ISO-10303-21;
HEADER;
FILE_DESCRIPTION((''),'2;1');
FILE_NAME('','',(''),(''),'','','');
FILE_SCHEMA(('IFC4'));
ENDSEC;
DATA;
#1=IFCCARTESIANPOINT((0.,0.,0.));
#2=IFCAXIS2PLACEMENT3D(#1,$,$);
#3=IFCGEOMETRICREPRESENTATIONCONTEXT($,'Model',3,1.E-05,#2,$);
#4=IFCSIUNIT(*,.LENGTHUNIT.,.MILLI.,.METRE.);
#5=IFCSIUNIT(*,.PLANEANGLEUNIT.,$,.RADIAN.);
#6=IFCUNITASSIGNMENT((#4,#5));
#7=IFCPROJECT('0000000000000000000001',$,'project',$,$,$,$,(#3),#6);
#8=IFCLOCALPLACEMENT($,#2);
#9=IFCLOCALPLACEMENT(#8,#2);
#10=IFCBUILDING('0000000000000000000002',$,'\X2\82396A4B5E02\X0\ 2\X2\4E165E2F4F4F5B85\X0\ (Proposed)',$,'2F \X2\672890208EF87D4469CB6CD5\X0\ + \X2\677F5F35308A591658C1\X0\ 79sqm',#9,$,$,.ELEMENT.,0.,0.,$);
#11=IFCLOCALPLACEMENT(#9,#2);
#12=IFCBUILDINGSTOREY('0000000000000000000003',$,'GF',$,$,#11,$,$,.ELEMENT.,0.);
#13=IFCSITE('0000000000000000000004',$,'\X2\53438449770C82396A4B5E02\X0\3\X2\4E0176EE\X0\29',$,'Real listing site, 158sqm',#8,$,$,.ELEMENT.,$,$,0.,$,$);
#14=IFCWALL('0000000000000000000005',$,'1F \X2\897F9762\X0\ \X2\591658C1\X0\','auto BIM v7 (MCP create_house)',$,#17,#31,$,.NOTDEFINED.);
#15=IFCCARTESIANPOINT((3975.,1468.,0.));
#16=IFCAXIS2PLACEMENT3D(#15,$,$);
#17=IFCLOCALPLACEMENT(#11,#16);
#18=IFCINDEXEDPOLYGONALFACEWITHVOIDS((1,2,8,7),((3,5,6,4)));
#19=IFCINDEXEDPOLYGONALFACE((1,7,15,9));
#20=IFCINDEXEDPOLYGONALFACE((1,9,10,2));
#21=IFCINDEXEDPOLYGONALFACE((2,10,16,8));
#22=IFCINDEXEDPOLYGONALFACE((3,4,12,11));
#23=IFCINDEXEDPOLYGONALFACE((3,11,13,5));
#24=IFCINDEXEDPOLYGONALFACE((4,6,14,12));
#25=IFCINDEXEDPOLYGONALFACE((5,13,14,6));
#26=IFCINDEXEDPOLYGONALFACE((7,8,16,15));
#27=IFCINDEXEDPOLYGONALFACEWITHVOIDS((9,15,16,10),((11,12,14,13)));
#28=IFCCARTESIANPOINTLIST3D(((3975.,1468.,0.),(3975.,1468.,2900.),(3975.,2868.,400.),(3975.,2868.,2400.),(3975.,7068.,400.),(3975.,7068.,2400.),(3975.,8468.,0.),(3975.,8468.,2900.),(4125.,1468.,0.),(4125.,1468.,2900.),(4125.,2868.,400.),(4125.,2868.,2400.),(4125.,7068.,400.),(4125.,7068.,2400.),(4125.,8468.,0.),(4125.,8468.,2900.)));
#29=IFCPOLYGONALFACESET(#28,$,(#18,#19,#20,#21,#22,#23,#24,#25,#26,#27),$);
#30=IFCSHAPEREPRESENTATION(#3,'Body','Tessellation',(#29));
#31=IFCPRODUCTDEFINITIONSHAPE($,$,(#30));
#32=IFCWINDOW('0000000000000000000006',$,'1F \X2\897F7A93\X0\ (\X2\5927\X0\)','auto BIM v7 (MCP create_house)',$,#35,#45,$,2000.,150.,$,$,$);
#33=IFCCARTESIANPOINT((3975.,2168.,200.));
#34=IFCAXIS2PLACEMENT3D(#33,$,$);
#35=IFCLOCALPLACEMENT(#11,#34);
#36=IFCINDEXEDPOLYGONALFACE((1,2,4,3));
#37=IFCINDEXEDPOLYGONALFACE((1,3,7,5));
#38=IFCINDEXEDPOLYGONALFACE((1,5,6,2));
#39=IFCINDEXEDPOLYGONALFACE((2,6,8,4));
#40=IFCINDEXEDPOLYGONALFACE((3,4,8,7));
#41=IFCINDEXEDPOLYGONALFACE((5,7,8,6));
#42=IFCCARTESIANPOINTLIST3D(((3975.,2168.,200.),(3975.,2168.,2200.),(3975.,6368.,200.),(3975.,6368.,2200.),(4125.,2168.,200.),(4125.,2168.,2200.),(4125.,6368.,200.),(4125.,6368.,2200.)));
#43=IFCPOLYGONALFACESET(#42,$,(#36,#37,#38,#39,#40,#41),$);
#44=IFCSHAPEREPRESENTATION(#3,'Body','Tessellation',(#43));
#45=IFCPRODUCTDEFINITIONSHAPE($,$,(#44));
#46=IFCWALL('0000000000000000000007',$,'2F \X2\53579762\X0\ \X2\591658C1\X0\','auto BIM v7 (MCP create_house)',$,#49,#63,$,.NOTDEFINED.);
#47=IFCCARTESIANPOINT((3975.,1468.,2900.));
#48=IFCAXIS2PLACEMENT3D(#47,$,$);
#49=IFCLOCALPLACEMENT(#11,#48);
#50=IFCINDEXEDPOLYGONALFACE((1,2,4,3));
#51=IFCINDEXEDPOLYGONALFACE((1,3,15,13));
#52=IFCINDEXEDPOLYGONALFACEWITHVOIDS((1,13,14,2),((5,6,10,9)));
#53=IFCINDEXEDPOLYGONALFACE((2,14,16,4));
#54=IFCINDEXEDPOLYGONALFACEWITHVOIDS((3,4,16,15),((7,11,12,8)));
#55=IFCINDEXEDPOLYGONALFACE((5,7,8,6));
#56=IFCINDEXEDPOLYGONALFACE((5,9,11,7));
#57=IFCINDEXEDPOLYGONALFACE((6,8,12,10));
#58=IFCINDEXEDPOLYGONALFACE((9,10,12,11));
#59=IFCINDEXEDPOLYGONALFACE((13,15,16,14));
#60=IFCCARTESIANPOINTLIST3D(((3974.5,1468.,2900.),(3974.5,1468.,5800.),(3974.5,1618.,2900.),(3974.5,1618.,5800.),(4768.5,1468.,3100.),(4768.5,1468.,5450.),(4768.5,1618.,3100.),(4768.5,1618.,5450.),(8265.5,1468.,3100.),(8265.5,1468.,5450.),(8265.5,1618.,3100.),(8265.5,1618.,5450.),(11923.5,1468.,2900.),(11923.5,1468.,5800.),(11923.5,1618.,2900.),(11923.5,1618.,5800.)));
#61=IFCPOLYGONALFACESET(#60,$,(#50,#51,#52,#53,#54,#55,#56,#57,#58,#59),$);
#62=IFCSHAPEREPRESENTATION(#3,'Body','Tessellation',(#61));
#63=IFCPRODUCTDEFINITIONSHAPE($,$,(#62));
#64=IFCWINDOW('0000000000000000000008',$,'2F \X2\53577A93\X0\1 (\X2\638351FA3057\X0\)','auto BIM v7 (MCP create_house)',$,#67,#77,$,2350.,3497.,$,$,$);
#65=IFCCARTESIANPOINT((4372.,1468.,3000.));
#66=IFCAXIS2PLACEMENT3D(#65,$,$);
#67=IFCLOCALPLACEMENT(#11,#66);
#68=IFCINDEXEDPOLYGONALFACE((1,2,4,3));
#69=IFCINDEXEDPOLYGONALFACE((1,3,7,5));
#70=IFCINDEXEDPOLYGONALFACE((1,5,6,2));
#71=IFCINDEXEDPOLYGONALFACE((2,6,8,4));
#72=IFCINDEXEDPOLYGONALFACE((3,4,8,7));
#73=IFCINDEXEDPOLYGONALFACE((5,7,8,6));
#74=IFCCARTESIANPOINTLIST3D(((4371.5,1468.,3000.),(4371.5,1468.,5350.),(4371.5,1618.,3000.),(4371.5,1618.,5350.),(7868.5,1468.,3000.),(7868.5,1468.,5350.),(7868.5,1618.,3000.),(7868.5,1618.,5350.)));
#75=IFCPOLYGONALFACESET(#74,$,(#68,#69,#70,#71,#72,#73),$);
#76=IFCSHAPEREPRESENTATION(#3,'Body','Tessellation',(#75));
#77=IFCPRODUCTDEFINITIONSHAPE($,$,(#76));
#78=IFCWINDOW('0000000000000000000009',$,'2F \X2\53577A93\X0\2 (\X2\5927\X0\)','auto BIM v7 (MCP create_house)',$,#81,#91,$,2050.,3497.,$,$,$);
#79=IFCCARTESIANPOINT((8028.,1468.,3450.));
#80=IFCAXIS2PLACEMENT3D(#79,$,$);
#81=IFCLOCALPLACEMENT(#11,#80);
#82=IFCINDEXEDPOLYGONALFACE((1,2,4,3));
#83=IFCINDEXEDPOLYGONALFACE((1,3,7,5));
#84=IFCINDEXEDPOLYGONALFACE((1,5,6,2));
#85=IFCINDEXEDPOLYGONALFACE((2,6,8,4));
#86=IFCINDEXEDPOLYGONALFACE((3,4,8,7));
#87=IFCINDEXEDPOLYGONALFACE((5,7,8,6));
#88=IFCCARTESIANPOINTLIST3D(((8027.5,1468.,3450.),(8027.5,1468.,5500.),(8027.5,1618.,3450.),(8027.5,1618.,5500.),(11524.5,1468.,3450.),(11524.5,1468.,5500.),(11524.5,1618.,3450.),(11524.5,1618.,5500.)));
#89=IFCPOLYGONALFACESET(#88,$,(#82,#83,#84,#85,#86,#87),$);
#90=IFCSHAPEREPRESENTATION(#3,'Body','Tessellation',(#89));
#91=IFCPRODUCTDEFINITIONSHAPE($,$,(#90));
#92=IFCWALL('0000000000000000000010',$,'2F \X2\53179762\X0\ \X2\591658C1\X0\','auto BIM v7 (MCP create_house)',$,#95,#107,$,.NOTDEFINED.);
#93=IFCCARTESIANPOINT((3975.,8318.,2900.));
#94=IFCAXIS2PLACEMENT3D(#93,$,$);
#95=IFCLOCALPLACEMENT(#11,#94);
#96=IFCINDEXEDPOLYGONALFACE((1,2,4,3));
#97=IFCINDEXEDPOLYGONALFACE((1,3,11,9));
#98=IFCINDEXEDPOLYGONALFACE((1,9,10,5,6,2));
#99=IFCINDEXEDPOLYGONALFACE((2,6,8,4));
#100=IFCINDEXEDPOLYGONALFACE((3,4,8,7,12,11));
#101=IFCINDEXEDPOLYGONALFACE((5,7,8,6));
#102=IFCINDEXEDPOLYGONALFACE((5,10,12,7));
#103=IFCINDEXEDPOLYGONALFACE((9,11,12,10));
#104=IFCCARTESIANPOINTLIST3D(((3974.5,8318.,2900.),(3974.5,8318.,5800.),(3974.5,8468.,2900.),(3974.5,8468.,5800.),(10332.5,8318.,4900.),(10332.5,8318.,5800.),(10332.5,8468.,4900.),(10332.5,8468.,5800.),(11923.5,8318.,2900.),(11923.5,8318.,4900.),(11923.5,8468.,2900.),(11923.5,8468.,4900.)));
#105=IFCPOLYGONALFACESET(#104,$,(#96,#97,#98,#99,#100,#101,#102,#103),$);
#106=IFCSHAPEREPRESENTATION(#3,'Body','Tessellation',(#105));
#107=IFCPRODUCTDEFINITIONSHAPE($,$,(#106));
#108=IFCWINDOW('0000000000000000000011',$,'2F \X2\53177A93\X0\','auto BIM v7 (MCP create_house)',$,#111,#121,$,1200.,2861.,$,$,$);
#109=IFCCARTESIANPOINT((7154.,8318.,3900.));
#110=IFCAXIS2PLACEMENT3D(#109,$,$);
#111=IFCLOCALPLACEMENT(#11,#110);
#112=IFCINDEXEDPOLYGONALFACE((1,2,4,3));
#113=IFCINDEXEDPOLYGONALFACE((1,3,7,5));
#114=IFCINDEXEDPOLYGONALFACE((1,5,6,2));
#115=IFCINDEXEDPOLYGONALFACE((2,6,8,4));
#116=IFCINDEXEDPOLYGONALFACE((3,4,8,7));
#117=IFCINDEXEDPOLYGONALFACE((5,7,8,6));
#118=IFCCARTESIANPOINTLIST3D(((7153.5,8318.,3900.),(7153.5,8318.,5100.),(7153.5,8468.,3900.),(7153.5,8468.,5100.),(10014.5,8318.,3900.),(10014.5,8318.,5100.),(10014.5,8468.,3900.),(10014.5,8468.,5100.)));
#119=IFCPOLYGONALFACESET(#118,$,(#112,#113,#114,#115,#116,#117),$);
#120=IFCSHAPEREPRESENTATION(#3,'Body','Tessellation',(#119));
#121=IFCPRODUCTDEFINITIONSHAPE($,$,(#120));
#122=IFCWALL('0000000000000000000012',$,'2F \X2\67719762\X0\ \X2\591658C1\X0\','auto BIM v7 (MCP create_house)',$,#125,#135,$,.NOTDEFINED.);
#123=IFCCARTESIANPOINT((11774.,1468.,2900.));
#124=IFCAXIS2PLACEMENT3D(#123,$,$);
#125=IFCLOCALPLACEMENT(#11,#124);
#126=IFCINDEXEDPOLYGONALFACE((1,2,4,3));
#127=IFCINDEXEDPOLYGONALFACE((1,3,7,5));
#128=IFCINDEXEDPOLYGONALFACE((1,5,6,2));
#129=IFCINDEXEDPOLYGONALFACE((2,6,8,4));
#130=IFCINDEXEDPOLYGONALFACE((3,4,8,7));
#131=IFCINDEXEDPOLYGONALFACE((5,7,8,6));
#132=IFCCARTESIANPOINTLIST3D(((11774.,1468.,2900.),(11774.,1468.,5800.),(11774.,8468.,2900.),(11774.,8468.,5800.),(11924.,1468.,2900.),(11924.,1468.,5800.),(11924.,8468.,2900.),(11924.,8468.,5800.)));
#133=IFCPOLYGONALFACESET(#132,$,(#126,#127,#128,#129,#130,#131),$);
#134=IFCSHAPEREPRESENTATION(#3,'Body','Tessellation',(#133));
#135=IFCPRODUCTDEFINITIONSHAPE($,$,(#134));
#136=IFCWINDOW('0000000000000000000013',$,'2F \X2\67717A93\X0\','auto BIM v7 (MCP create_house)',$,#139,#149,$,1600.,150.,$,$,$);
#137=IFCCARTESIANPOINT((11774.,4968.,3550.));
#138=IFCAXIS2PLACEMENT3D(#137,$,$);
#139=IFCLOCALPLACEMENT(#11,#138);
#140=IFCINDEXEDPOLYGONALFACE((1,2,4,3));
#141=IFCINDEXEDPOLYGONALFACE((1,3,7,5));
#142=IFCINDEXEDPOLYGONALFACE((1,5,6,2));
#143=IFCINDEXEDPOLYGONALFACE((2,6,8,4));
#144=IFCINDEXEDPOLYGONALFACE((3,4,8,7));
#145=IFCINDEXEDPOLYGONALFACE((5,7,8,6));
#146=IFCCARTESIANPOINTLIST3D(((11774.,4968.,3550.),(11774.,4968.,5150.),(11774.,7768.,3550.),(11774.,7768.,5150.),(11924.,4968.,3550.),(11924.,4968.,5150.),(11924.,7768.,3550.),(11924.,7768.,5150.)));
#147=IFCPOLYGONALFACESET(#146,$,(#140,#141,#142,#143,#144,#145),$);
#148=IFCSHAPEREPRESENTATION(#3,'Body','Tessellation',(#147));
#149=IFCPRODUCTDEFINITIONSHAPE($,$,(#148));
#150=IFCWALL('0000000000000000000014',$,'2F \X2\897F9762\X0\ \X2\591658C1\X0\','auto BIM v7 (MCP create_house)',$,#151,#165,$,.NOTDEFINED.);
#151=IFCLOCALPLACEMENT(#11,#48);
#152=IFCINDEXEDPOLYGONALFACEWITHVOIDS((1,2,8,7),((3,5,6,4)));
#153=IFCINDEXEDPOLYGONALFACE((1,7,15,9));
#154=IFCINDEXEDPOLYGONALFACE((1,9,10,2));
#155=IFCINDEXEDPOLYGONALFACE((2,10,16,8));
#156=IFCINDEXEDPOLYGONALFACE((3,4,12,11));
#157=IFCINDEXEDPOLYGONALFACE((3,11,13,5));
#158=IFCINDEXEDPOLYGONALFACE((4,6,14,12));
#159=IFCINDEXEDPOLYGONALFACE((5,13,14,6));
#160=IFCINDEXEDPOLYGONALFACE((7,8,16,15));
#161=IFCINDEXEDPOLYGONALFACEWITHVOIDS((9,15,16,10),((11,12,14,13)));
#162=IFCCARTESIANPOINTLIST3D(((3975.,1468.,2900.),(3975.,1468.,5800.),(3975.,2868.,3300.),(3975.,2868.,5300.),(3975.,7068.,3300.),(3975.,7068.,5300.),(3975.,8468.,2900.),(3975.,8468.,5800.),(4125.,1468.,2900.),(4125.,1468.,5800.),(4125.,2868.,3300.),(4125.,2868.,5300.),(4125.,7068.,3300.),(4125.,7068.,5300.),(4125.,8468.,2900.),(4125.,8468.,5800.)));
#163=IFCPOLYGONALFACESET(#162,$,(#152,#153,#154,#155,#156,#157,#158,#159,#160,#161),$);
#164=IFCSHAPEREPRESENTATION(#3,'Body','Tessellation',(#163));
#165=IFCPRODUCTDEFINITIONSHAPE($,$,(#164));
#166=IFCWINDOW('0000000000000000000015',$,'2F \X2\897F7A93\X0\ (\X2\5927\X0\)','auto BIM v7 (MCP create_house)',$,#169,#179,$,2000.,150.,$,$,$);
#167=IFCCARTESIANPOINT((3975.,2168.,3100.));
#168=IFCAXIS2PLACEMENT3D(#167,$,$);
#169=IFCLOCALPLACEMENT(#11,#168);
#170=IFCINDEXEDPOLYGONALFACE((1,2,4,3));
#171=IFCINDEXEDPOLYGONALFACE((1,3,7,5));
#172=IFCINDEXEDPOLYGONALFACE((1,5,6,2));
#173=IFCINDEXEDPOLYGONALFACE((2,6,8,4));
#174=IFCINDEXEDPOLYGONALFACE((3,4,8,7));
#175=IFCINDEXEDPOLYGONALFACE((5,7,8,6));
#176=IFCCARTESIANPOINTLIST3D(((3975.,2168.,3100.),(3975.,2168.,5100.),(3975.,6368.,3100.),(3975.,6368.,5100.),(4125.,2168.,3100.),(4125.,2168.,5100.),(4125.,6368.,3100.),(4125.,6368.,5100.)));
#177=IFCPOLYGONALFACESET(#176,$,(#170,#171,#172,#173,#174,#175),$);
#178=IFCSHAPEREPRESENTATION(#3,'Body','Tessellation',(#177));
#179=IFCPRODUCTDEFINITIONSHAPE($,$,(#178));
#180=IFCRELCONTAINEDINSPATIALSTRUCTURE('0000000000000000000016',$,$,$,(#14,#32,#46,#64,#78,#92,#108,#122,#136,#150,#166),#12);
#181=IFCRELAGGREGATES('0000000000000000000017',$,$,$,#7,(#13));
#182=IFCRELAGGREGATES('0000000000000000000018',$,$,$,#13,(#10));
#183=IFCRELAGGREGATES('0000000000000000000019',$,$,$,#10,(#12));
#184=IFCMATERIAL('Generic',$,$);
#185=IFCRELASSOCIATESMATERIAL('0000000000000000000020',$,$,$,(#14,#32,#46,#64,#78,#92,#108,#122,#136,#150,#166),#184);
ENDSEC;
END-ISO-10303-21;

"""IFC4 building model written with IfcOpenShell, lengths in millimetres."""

from ifc_helpers import new_model, si_unit, frame, frame_2d, origin, place, context, project, spatial, rectangle, extrude, material, element, fill, save


model = new_model("IFC4")

# Units and contexts
model_context = context("Model", 3, precision=1e-05, world=origin())
ifc_project = project(units=[si_unit("LENGTHUNIT", "METRE", prefix="MILLI"), si_unit("PLANEANGLEUNIT", "RADIAN")], contexts=[model_context])

# Site, building, storey
site_placement = place(None, origin())
site = spatial("IfcSite", under=ifc_project, at=site_placement, Name="千葉県船橋市3丁目29", ObjectType="Real listing site, 158sqm", CompositionType="ELEMENT", RefElevation=0.0)
building_placement = place(site_placement, origin())
building = spatial("IfcBuilding", under=site, at=building_placement, Name="船橋市 2世帯住宅 (Proposed)", ObjectType="2F 木造軸組構法 + 板張り外壁 79sqm", CompositionType="ELEMENT", ElevationOfRefHeight=0.0, ElevationOfTerrain=0.0)
storey_placement = place(building_placement, origin())
storey = spatial("IfcBuildingStorey", under=building, at=storey_placement, Name="GF", CompositionType="ELEMENT", Elevation=0.0)

# Shared definitions
ifc_material = material(Name="Generic")

# Wall, opening, window
wall_1_placement = place(storey_placement, frame((3975.0, 1468.0, 0.0)))
wall_1 = element("IfcWall", 1, at=wall_1_placement, inside=storey, material=ifc_material, Name="1F 西面 外壁", Description="auto BIM v7 (MCP create_house)", PredefinedType="NOTDEFINED", context=model_context, shape_type="SweptSolid", body=[
    extrude(rectangle(XDim=150.0, YDim=7000.0, at=frame_2d((75.0, 3500.0))), frame((3975.0, 1468.0, 0.0)), (0.0, 0.0, 1.0), 2900.0),
])
opening_1_placement = place(storey_placement, frame((3975.0, 2168.0, 200.0)))
opening_1 = element("IfcOpeningElement", 2, at=opening_1_placement, cuts=wall_1, PredefinedType="NOTDEFINED", context=model_context, shape_type="SweptSolid", body=[
    extrude(rectangle(XDim=150.0, YDim=4200.0, at=frame_2d((75.0, 2100.0))), frame((3975.0, 2168.0, 200.0)), (0.0, 0.0, 1.0), 2000.0),
])
window_1_placement = place(storey_placement, frame((3975.0, 2168.0, 200.0)))
window_1 = element("IfcWindow", 3, at=window_1_placement, inside=storey, material=ifc_material, Name="1F 西窓 (大)", Description="auto BIM v7 (MCP create_house)", OverallHeight=2000.0, OverallWidth=150.0, context=model_context, shape_type="SweptSolid", body=[
    extrude(rectangle(XDim=150.0, YDim=4200.0, at=frame_2d((75.0, 2100.0))), frame((3975.0, 2168.0, 200.0)), (0.0, 0.0, 1.0), 2000.0),
])
fill(opening_1, window_1)

# Wall, openings, windows
wall_2_placement = place(storey_placement, frame((3975.0, 1468.0, 2900.0)))
wall_2 = element("IfcWall", 4, at=wall_2_placement, inside=storey, material=ifc_material, Name="2F 南面 外壁", Description="auto BIM v7 (MCP create_house)", PredefinedType="NOTDEFINED", context=model_context, shape_type="SweptSolid", body=[
    extrude(rectangle(XDim=7949.0, YDim=150.0, at=frame_2d((3974.0, 75.0))), frame((3975.0, 1468.0, 2900.0)), (0.0, 0.0, 1.0), 2900.0),
])
opening_2_placement = place(storey_placement, frame((4372.0, 1468.0, 3000.0)))
opening_2 = element("IfcOpeningElement", 5, at=opening_2_placement, cuts=wall_2, PredefinedType="NOTDEFINED", context=model_context, shape_type="SweptSolid", body=[
    extrude(rectangle(XDim=3497.0, YDim=150.0, at=frame_2d((1748.0, 75.0))), frame((4372.0, 1468.0, 3000.0)), (0.0, 0.0, 1.0), 2350.0),
])
opening_3_placement = place(storey_placement, frame((8028.0, 1468.0, 3450.0)))
opening_3 = element("IfcOpeningElement", 6, at=opening_3_placement, cuts=wall_2, PredefinedType="NOTDEFINED", context=model_context, shape_type="SweptSolid", body=[
    extrude(rectangle(XDim=3497.0, YDim=150.0, at=frame_2d((1748.0, 75.0))), frame((8028.0, 1468.0, 3450.0)), (0.0, 0.0, 1.0), 2050.0),
])
window_2_placement = place(storey_placement, frame((4372.0, 1468.0, 3000.0)))
window_2 = element("IfcWindow", 7, at=window_2_placement, inside=storey, material=ifc_material, Name="2F 南窓1 (掃出し)", Description="auto BIM v7 (MCP create_house)", OverallHeight=2350.0, OverallWidth=3497.0, context=model_context, shape_type="SweptSolid", body=[
    extrude(rectangle(XDim=3497.0, YDim=150.0, at=frame_2d((1748.0, 75.0))), frame((4372.0, 1468.0, 3000.0)), (0.0, 0.0, 1.0), 2350.0),
])
fill(opening_2, window_2)
window_3_placement = place(storey_placement, frame((8028.0, 1468.0, 3450.0)))
window_3 = element("IfcWindow", 8, at=window_3_placement, inside=storey, material=ifc_material, Name="2F 南窓2 (大)", Description="auto BIM v7 (MCP create_house)", OverallHeight=2050.0, OverallWidth=3497.0, context=model_context, shape_type="SweptSolid", body=[
    extrude(rectangle(XDim=3497.0, YDim=150.0, at=frame_2d((1748.0, 75.0))), frame((8028.0, 1468.0, 3450.0)), (0.0, 0.0, 1.0), 2050.0),
])
fill(opening_3, window_3)

# Walls, openings, windows
wall_3_placement = place(storey_placement, frame((3975.0, 8318.0, 2900.0)))
wall_3 = element("IfcWall", 9, at=wall_3_placement, inside=storey, material=ifc_material, Name="2F 北面 外壁", Description="auto BIM v7 (MCP create_house)", PredefinedType="NOTDEFINED", context=model_context, shape_type="SweptSolid", body=[
    extrude(rectangle(XDim=7949.0, YDim=150.0, at=frame_2d((3974.0, 75.0))), frame((3975.0, 8318.0, 2900.0)), (0.0, 0.0, 1.0), 2900.0),
])
opening_4_placement = place(storey_placement, frame((7154.0, 8318.0, 3900.0)))
opening_4 = element("IfcOpeningElement", 10, at=opening_4_placement, cuts=wall_3, PredefinedType="NOTDEFINED", context=model_context, shape_type="SweptSolid", body=[
    extrude(rectangle(XDim=2861.0, YDim=150.0, at=frame_2d((1430.0, 75.0))), frame((7154.0, 8318.0, 3900.0)), (0.0, 0.0, 1.0), 1200.0),
])
window_4_placement = place(storey_placement, frame((7154.0, 8318.0, 3900.0)))
window_4 = element("IfcWindow", 11, at=window_4_placement, inside=storey, material=ifc_material, Name="2F 北窓", Description="auto BIM v7 (MCP create_house)", OverallHeight=1200.0, OverallWidth=2861.0, context=model_context, shape_type="SweptSolid", body=[
    extrude(rectangle(XDim=2861.0, YDim=150.0, at=frame_2d((1430.0, 75.0))), frame((7154.0, 8318.0, 3900.0)), (0.0, 0.0, 1.0), 1200.0),
])
fill(opening_4, window_4)
wall_4_placement = place(storey_placement, frame((11774.0, 1468.0, 2900.0)))
wall_4 = element("IfcWall", 12, at=wall_4_placement, inside=storey, material=ifc_material, Name="2F 東面 外壁", Description="auto BIM v7 (MCP create_house)", PredefinedType="NOTDEFINED", context=model_context, shape_type="SweptSolid", body=[
    extrude(rectangle(XDim=150.0, YDim=7000.0, at=frame_2d((75.0, 3500.0))), frame((11774.0, 1468.0, 2900.0)), (0.0, 0.0, 1.0), 2900.0),
])
opening_5_placement = place(storey_placement, frame((11774.0, 4968.0, 3550.0)))
opening_5 = element("IfcOpeningElement", 13, at=opening_5_placement, cuts=wall_4, PredefinedType="NOTDEFINED", context=model_context, shape_type="SweptSolid", body=[
    extrude(rectangle(XDim=150.0, YDim=2800.0, at=frame_2d((75.0, 1400.0))), frame((11774.0, 4968.0, 3550.0)), (0.0, 0.0, 1.0), 1600.0),
])
window_5_placement = place(storey_placement, frame((11774.0, 4968.0, 3550.0)))
window_5 = element("IfcWindow", 14, at=window_5_placement, inside=storey, material=ifc_material, Name="2F 東窓", Description="auto BIM v7 (MCP create_house)", OverallHeight=1600.0, OverallWidth=150.0, context=model_context, shape_type="SweptSolid", body=[
    extrude(rectangle(XDim=150.0, YDim=2800.0, at=frame_2d((75.0, 1400.0))), frame((11774.0, 4968.0, 3550.0)), (0.0, 0.0, 1.0), 1600.0),
])
fill(opening_5, window_5)
wall_5_placement = place(storey_placement, frame((3975.0, 1468.0, 2900.0)))
wall_5 = element("IfcWall", 15, at=wall_5_placement, inside=storey, material=ifc_material, Name="2F 西面 外壁", Description="auto BIM v7 (MCP create_house)", PredefinedType="NOTDEFINED", context=model_context, shape_type="SweptSolid", body=[
    extrude(rectangle(XDim=150.0, YDim=7000.0, at=frame_2d((75.0, 3500.0))), frame((3975.0, 1468.0, 2900.0)), (0.0, 0.0, 1.0), 2900.0),
])
opening_6_placement = place(storey_placement, frame((3975.0, 2168.0, 3100.0)))
opening_6 = element("IfcOpeningElement", 16, at=opening_6_placement, cuts=wall_5, PredefinedType="NOTDEFINED", context=model_context, shape_type="SweptSolid", body=[
    extrude(rectangle(XDim=150.0, YDim=4200.0, at=frame_2d((75.0, 2100.0))), frame((3975.0, 2168.0, 3100.0)), (0.0, 0.0, 1.0), 2000.0),
])
window_6_placement = place(storey_placement, frame((3975.0, 2168.0, 3100.0)))
window_6 = element("IfcWindow", 17, at=window_6_placement, inside=storey, material=ifc_material, Name="2F 西窓 (大)", Description="auto BIM v7 (MCP create_house)", OverallHeight=2000.0, OverallWidth=150.0, context=model_context, shape_type="SweptSolid", body=[
    extrude(rectangle(XDim=150.0, YDim=4200.0, at=frame_2d((75.0, 2100.0))), frame((3975.0, 2168.0, 3100.0)), (0.0, 0.0, 1.0), 2000.0),
])
fill(opening_6, window_6)

save(model, "model.ifc")
